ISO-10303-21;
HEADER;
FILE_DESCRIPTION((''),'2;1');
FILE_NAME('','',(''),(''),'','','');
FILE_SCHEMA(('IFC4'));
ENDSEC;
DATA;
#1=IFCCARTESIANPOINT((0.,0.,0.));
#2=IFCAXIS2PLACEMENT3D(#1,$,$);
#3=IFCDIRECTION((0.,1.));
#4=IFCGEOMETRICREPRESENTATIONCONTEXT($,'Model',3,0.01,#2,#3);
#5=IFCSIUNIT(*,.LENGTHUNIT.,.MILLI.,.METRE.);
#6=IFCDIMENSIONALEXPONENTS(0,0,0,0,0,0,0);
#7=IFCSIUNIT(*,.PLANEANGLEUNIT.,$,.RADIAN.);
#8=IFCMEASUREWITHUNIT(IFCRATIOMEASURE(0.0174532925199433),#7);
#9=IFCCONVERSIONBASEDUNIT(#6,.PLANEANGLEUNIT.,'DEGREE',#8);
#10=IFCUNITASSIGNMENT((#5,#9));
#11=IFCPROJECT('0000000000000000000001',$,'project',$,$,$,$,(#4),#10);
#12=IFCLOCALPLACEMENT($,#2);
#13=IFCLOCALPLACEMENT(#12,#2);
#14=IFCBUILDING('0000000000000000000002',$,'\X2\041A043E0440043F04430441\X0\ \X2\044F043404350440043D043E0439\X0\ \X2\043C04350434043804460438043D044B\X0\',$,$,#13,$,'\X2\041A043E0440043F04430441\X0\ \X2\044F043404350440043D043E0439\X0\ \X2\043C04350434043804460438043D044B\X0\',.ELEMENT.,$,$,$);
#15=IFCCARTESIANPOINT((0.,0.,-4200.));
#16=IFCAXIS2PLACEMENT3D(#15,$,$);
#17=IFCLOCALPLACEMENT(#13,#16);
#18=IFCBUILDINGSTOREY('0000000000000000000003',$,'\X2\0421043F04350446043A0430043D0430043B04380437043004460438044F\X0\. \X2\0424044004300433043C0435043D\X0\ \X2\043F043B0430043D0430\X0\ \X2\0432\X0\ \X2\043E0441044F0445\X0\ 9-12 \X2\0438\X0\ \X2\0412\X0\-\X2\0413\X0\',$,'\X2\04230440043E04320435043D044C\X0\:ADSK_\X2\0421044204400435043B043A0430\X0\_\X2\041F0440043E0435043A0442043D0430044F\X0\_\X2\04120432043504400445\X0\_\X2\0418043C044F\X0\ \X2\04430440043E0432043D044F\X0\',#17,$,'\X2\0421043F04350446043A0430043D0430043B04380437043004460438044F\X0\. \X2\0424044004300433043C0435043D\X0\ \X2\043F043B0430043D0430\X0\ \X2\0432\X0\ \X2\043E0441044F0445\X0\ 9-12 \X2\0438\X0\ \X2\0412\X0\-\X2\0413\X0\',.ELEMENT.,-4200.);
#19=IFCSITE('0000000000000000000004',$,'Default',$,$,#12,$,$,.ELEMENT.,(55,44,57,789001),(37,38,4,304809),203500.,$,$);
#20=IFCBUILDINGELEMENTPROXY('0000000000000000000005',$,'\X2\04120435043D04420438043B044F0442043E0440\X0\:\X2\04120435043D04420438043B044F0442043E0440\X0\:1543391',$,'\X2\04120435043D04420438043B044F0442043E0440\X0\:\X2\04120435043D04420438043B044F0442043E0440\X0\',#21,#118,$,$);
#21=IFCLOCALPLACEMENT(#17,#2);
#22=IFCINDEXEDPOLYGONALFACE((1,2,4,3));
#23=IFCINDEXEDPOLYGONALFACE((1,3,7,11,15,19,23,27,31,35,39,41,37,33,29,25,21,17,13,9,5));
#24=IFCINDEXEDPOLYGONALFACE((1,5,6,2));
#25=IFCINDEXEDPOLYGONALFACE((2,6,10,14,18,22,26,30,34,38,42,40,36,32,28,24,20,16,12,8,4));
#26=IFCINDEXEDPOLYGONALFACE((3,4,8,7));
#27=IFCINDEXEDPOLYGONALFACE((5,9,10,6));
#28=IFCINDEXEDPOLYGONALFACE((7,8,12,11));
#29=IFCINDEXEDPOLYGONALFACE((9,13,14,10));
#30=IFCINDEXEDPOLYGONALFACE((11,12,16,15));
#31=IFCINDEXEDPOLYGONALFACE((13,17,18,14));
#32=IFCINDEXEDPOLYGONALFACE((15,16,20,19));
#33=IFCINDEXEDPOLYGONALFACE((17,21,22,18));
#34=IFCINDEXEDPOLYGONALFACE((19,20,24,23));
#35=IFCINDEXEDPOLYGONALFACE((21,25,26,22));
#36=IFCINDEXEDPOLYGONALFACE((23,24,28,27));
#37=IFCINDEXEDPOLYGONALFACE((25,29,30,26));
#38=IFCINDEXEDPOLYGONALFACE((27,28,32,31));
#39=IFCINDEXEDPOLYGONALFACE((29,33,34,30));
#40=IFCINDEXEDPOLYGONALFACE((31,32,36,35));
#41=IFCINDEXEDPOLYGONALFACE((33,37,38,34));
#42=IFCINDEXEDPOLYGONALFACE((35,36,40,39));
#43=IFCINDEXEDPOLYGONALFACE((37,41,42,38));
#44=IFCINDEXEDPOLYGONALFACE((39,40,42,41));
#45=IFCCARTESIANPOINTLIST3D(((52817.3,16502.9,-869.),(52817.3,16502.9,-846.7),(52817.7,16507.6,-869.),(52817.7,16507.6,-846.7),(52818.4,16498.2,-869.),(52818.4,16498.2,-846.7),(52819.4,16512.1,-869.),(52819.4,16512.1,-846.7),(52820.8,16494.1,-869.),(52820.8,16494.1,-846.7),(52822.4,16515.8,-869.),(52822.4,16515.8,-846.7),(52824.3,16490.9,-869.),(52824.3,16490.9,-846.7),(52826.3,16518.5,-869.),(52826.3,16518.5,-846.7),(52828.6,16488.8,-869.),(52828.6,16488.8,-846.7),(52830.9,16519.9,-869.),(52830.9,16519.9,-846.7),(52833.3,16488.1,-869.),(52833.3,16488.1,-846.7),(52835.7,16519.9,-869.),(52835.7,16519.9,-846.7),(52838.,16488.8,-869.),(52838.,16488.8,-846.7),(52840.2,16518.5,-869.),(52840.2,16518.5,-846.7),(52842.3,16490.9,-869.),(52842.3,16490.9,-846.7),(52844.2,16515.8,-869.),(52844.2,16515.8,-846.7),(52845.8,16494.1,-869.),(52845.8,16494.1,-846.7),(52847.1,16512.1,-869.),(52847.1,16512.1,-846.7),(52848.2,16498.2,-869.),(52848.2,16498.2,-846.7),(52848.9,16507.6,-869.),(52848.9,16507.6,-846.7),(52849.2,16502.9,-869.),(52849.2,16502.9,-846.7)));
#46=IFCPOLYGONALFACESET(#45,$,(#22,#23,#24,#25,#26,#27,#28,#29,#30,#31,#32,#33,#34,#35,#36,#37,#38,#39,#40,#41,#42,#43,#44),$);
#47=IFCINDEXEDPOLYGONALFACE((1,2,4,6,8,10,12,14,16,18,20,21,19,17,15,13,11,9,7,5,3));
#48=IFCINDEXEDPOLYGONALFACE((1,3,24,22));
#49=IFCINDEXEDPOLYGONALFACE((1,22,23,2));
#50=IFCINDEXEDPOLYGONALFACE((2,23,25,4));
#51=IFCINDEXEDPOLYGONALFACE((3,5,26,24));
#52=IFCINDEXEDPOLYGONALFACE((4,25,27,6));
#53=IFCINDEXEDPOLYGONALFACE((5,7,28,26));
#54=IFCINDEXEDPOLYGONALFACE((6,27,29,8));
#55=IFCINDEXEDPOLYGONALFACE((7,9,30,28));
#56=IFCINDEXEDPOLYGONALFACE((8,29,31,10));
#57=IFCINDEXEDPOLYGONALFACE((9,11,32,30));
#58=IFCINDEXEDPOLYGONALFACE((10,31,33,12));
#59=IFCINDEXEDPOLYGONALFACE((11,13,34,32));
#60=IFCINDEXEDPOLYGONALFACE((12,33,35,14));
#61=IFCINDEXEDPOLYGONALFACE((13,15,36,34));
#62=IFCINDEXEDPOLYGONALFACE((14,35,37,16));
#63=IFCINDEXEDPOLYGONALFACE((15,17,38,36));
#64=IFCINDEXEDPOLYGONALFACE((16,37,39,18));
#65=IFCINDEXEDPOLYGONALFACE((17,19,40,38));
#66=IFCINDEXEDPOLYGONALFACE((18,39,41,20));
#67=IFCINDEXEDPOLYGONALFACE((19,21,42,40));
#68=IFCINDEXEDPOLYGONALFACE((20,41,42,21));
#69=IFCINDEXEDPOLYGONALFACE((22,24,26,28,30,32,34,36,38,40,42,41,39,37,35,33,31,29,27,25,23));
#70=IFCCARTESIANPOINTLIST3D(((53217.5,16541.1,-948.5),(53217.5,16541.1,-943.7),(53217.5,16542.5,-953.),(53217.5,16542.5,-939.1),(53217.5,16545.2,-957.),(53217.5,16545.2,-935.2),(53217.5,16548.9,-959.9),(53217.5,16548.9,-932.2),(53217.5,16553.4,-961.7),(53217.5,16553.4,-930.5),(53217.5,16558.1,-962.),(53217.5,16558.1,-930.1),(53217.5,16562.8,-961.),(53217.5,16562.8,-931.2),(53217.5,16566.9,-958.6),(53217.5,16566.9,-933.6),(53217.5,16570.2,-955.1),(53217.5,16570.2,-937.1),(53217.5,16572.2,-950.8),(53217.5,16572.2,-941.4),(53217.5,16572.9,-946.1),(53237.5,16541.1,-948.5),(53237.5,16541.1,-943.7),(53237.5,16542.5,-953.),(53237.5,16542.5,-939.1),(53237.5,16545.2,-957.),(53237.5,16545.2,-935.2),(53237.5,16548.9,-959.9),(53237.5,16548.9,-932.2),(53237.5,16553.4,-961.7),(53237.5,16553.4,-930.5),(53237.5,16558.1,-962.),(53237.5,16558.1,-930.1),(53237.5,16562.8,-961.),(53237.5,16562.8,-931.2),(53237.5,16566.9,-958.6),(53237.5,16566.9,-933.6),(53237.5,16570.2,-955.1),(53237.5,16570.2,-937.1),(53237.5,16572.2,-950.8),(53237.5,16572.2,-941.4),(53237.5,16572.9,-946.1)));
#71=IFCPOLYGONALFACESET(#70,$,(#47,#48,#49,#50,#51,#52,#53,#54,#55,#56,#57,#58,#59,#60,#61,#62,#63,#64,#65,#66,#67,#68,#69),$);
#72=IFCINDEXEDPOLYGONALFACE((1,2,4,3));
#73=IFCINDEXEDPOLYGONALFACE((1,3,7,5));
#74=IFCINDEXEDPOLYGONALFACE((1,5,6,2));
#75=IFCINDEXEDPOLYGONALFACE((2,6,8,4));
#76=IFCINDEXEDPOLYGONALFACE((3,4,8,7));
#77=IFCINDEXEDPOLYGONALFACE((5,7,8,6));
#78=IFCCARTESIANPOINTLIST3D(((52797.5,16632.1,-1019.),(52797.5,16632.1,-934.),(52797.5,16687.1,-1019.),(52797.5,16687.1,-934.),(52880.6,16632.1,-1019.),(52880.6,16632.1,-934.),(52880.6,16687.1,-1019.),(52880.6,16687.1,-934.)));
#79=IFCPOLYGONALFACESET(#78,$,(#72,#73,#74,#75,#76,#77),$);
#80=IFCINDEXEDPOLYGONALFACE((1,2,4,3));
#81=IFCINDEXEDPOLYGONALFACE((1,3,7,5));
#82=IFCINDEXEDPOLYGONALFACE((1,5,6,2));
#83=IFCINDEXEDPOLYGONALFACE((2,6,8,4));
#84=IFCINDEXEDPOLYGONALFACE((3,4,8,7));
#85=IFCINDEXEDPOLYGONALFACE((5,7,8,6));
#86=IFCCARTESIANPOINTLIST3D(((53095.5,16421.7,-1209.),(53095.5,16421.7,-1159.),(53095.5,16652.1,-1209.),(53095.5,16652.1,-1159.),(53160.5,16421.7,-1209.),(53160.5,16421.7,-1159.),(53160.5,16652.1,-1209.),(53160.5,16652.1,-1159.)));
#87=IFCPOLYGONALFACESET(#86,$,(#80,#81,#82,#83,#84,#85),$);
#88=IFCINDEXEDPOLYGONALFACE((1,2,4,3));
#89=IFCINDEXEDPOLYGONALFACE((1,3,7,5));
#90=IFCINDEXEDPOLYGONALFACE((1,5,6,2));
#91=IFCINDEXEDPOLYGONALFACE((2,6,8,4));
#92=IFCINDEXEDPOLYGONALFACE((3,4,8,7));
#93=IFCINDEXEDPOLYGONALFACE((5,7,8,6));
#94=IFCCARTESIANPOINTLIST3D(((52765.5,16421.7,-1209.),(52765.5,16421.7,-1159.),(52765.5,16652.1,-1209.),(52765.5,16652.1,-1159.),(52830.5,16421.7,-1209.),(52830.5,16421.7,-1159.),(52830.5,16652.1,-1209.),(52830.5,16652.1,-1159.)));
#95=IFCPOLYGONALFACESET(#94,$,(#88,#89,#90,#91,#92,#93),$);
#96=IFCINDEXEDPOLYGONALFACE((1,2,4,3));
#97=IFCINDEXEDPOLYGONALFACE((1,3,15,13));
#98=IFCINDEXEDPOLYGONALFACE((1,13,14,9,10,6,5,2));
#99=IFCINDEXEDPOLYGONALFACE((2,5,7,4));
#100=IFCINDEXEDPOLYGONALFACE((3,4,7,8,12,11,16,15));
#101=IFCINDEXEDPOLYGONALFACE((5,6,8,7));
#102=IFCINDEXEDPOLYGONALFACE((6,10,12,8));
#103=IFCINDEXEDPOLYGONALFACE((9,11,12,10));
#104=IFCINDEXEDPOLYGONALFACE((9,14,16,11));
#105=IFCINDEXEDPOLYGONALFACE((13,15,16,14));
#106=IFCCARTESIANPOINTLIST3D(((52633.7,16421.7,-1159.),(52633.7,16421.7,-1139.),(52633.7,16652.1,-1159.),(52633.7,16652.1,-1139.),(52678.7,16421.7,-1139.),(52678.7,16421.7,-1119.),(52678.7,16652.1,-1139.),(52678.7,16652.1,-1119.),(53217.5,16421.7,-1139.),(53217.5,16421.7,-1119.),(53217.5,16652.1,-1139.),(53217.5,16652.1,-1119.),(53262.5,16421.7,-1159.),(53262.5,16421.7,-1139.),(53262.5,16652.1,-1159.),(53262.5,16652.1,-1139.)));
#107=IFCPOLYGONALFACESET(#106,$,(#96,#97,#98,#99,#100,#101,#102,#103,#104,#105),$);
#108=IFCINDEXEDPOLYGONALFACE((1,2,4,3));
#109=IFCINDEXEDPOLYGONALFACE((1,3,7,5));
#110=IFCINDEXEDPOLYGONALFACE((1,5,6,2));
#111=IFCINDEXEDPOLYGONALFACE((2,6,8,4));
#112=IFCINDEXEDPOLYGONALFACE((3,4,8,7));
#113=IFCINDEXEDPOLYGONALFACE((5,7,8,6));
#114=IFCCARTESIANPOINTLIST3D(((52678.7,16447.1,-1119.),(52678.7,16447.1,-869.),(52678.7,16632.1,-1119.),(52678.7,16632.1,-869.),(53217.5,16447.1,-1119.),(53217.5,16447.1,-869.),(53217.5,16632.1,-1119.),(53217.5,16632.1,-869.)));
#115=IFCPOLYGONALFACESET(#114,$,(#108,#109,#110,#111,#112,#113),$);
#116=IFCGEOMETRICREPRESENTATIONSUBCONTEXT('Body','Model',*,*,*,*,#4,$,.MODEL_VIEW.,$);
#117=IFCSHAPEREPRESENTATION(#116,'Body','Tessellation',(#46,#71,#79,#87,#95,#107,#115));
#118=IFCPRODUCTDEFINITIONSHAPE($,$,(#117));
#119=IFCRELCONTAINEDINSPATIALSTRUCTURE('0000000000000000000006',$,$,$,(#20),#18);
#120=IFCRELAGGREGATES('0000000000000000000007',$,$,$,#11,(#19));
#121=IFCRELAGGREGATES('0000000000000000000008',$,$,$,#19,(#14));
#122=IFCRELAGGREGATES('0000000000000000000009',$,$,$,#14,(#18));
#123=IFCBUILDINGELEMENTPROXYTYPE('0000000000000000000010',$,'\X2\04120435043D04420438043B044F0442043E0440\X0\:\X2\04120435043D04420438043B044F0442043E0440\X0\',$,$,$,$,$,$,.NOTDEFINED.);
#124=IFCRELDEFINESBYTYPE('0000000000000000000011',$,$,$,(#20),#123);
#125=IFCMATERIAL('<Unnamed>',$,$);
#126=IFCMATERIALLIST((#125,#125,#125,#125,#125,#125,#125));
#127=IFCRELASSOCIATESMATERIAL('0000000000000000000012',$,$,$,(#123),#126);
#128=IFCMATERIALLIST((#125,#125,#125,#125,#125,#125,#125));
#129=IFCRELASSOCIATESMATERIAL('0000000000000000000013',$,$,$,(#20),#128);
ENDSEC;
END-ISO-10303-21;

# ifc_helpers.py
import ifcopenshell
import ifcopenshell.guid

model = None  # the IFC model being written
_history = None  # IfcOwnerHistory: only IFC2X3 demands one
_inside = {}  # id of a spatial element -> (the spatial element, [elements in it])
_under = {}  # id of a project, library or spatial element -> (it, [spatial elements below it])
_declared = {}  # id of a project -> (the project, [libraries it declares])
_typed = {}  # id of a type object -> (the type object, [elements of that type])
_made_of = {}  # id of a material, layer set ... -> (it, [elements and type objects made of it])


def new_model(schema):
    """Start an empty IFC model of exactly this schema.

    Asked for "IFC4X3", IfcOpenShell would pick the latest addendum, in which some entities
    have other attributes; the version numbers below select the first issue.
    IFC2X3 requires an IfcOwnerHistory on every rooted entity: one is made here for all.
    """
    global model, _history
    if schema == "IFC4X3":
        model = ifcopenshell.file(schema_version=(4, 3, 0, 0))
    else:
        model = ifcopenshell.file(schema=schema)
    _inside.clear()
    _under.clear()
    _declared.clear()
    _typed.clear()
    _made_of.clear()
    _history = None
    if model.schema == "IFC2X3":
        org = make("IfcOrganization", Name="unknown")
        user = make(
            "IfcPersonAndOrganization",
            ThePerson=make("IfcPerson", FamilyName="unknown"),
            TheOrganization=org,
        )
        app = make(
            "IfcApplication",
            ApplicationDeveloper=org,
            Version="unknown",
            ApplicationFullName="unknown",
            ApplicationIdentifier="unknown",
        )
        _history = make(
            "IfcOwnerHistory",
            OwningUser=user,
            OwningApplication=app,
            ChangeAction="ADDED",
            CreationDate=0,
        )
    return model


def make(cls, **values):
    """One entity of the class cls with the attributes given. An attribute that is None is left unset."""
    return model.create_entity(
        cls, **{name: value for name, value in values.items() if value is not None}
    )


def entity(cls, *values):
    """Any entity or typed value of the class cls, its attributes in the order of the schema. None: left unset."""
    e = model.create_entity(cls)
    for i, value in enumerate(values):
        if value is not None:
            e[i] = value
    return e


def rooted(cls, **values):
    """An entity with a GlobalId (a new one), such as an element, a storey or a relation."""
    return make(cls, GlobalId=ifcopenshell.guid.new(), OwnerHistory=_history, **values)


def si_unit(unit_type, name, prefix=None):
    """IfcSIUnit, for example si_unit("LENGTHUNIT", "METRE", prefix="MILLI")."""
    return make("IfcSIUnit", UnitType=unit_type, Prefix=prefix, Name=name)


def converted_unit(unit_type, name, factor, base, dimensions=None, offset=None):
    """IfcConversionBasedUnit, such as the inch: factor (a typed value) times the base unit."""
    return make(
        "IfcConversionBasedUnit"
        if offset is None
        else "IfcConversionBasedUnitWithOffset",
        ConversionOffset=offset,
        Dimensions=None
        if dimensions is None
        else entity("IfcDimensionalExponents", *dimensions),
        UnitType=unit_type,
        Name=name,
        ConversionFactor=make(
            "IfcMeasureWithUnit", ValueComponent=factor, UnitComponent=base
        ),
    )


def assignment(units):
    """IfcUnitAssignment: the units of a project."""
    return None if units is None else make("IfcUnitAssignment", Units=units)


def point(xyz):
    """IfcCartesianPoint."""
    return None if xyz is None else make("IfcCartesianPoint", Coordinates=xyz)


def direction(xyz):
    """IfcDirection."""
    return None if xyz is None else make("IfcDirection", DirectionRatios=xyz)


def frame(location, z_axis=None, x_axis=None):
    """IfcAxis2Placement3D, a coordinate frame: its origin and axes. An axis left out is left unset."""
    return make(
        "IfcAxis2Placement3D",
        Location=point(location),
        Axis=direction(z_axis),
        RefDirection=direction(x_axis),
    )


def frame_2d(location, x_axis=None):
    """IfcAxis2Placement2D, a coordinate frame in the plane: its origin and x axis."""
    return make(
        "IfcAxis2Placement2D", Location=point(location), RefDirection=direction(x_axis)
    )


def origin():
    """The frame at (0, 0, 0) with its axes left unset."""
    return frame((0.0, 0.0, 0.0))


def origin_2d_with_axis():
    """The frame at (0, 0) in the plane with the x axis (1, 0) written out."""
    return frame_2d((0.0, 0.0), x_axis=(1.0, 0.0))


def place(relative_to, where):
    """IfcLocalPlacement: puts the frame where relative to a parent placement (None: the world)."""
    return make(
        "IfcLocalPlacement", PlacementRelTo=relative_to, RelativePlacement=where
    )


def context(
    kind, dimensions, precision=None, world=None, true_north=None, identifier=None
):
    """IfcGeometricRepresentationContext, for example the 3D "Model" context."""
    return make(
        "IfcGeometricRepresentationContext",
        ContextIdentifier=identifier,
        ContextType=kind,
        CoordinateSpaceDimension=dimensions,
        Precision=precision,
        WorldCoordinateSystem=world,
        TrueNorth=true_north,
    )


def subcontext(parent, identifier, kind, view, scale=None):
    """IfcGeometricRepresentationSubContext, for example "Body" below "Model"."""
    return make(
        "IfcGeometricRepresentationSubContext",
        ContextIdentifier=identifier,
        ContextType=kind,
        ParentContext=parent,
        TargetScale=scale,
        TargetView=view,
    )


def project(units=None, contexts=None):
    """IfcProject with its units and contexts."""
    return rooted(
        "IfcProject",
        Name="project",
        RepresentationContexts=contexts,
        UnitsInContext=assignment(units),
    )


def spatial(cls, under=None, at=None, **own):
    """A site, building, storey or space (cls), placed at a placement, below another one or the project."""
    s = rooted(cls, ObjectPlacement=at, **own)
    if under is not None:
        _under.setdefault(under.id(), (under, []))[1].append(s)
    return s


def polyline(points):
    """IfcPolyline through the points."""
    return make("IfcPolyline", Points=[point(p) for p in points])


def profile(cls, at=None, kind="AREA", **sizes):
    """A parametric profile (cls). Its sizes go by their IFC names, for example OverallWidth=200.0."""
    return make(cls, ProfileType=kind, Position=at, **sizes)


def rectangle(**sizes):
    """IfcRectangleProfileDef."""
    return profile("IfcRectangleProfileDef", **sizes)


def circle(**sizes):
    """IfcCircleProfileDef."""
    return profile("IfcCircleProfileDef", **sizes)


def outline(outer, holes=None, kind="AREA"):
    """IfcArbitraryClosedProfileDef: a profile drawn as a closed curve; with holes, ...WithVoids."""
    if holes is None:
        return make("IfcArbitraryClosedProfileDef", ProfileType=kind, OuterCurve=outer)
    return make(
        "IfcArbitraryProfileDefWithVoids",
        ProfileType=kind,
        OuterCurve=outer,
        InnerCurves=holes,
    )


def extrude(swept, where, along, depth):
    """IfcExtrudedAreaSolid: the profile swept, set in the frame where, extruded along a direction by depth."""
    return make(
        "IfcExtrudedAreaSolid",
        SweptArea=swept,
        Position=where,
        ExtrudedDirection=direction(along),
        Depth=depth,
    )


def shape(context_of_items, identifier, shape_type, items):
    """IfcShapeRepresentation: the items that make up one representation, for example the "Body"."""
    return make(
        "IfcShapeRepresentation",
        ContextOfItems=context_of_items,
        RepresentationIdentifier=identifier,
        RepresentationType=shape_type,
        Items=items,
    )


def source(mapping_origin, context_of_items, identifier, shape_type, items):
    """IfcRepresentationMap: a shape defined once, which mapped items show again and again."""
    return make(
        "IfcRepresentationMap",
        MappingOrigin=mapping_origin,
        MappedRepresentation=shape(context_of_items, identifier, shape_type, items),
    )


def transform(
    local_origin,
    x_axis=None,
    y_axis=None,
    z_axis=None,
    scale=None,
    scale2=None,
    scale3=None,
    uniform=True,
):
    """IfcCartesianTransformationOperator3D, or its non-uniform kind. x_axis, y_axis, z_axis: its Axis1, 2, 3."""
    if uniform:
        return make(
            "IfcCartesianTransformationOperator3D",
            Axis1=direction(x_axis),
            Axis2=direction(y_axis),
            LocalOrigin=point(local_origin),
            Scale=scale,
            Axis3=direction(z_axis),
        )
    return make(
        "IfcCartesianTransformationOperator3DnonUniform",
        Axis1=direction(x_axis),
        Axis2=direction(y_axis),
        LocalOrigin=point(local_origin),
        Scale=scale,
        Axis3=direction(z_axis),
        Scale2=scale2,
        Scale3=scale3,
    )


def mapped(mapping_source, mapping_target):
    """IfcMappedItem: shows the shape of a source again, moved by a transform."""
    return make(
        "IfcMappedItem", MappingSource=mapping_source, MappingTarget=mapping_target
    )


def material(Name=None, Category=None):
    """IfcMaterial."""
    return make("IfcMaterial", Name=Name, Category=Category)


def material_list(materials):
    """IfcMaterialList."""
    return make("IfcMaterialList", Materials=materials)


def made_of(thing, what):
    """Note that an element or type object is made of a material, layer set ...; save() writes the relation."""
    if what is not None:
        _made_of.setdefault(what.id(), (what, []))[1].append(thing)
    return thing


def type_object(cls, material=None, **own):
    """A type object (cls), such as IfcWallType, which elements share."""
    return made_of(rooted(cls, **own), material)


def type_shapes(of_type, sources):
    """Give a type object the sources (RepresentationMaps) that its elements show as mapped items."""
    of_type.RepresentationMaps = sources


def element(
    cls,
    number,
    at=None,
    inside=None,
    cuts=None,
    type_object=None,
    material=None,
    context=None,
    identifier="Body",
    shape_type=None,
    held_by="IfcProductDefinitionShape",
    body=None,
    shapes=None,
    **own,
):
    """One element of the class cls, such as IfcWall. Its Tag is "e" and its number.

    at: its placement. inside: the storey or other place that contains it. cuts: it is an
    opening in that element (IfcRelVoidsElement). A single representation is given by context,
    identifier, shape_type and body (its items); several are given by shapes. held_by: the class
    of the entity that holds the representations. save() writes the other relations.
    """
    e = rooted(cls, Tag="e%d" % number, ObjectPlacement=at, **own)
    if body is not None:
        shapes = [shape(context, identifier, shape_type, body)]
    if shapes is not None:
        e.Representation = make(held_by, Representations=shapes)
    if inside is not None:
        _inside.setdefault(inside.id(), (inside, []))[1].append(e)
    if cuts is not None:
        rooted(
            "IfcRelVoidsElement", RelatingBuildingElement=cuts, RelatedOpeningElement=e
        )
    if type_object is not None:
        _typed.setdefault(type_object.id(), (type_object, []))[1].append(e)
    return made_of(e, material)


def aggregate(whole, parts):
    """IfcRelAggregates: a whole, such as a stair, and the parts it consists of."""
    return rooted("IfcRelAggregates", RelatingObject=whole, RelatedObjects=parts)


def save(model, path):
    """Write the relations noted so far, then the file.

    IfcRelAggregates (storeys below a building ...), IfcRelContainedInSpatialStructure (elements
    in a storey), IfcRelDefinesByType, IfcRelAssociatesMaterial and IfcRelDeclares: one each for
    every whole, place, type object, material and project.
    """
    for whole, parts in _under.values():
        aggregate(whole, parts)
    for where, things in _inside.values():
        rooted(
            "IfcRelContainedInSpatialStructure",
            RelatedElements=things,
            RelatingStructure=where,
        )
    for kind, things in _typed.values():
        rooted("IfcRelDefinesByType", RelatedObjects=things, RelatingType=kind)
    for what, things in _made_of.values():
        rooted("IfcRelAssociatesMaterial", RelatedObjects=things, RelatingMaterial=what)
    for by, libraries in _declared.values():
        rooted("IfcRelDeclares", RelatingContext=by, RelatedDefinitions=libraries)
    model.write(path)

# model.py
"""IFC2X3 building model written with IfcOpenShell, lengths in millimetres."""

from ifc_helpers import new_model, entity, si_unit, converted_unit, direction, frame, frame_2d, origin, origin_2d_with_axis, place, context, subcontext, project, spatial, polyline, rectangle, circle, outline, extrude, source, transform, mapped, material, material_list, type_object, type_shapes, element, save


model = new_model("IFC2X3")

# Units and contexts
model_context = context("Model", 3, precision=0.01, world=origin(), true_north=direction((0.0, 1.0)))
body_context = subcontext(model_context, "Body", "Model", "MODEL_VIEW")
ifc_project = project(units=[si_unit("LENGTHUNIT", "METRE", prefix="MILLI"), converted_unit("PLANEANGLEUNIT", "DEGREE", entity("IfcRatioMeasure", 0.0174532925199433), si_unit("PLANEANGLEUNIT", "RADIAN"), dimensions=[0, 0, 0, 0, 0, 0, 0])], contexts=[model_context])

# Site, building, storey
site_placement = place(None, frame((0.0, 0.0, 0.0)))
site = spatial("IfcSite", under=ifc_project, at=site_placement, Name="Default", CompositionType="ELEMENT", RefLatitude=(55, 44, 57, 789001), RefLongitude=(37, 38, 4, 304809), RefElevation=203500.0)
building_placement = place(site_placement, origin())
building = spatial("IfcBuilding", under=site, at=building_placement, Name="Корпус ядерной медицины", LongName="Корпус ядерной медицины", CompositionType="ELEMENT")
storey_placement = place(building_placement, frame((0.0, 0.0, -4200.0)))
storey = spatial("IfcBuildingStorey", under=building, at=storey_placement, Name="Спецканализация. Фрагмен плана в осях 9-12 и В-Г", ObjectType="Уровень:ADSK_Стрелка_Проектная_Вверх_Имя уровня", LongName="Спецканализация. Фрагмен плана в осях 9-12 и В-Г", CompositionType="ELEMENT", Elevation=-4200.0)

# Building element proxy
ifc_material_1 = material(Name="<Unnamed>")
ifc_material_list_1 = material_list([ifc_material_1, ifc_material_1, ifc_material_1, ifc_material_1, ifc_material_1, ifc_material_1, ifc_material_1])
ifc_material_list_2 = material_list([ifc_material_1, ifc_material_1, ifc_material_1, ifc_material_1, ifc_material_1, ifc_material_1, ifc_material_1])
building_element_proxy_type_1 = type_object("IfcBuildingElementProxyType", Name="Вентилятор:Вентилятор", PredefinedType="NOTDEFINED", material=ifc_material_list_2)
shared_shape_1 = source(origin(), body_context, "Body", "SweptSolid", [
    extrude(circle(Radius=16.0, at=frame_2d((0.0, 0.0), x_axis=(1.0, 0.0))), frame((15.8, 107.7, 250.0)), (0.0, 0.0, 1.0), 22.4),
    extrude(circle(Radius=16.0, at=frame_2d((0.0, 0.0), x_axis=(1.0, 0.0))), frame((-37.0, 492.0, 173.0), z_axis=(0.0, 1.0, 0.0), x_axis=(-1.0, 0.0, 0.0)), (0.0, 0.0, 1.0), 20.0),
    extrude(rectangle(XDim=83.1, YDim=55.0, at=origin_2d_with_axis()), frame((-139.7, 113.5, 100.0), z_axis=(0.0, 0.0, 1.0), x_axis=(0.0, 1.0, 0.0)), (0.0, 0.0, 1.0), 85.0),
    extrude(rectangle(XDim=230.4, YDim=65.0, at=frame_2d((0.0, 0.0), x_axis=(1.0, 0.0))), frame((-17.0, 402.4, -90.0), z_axis=(0.0, 0.0, 1.0), x_axis=(-1.0, 0.0, 0.0)), (0.0, 0.0, 1.0), 50.0),
    extrude(rectangle(XDim=230.4, YDim=65.0, at=origin_2d_with_axis()), frame((-17.0, 72.4, -90.0), z_axis=(0.0, 0.0, 1.0), x_axis=(-1.0, 0.0, 0.0)), (0.0, 0.0, 1.0), 50.0),
    extrude(outline(polyline([(0.0, -269.4), (20.0, -269.4), (20.0, 269.4), (0.0, 269.4), (0.0, 314.4), (-20.0, 314.4), (-20.0, -314.4), (0.0, -314.4), (0.0, -269.4)])), frame((-132.2, 222.5, -20.0), z_axis=(1.0, 0.0, 0.0), x_axis=(0.0, 0.0, 1.0)), (0.0, 0.0, 1.0), 230.4),
    extrude(rectangle(XDim=185.0, YDim=538.8, at=frame_2d((0.0, 0.0), x_axis=(1.0, 0.0))), frame((-19.7, 222.5, 0.0)), (0.0, 0.0, 1.0), 250.0),
])
type_shapes(building_element_proxy_type_1, [shared_shape_1])
proxy_1_placement = place(storey_placement, frame((52725.5, 16519.9, -1119.0), z_axis=(0.0, 0.0, 1.0), x_axis=(0.0, -1.0, 0.0)))
element("IfcBuildingElementProxy", 1, at=proxy_1_placement, inside=storey, type_object=building_element_proxy_type_1, material=ifc_material_list_1, Name="Вентилятор:Вентилятор:1543391", ObjectType="Вентилятор:Вентилятор", context=body_context, shape_type="MappedRepresentation", body=[
    mapped(shared_shape_1, transform((0.0, 0.0, 0.0), scale=1.0)),
])

save(model, "model.ifc")
